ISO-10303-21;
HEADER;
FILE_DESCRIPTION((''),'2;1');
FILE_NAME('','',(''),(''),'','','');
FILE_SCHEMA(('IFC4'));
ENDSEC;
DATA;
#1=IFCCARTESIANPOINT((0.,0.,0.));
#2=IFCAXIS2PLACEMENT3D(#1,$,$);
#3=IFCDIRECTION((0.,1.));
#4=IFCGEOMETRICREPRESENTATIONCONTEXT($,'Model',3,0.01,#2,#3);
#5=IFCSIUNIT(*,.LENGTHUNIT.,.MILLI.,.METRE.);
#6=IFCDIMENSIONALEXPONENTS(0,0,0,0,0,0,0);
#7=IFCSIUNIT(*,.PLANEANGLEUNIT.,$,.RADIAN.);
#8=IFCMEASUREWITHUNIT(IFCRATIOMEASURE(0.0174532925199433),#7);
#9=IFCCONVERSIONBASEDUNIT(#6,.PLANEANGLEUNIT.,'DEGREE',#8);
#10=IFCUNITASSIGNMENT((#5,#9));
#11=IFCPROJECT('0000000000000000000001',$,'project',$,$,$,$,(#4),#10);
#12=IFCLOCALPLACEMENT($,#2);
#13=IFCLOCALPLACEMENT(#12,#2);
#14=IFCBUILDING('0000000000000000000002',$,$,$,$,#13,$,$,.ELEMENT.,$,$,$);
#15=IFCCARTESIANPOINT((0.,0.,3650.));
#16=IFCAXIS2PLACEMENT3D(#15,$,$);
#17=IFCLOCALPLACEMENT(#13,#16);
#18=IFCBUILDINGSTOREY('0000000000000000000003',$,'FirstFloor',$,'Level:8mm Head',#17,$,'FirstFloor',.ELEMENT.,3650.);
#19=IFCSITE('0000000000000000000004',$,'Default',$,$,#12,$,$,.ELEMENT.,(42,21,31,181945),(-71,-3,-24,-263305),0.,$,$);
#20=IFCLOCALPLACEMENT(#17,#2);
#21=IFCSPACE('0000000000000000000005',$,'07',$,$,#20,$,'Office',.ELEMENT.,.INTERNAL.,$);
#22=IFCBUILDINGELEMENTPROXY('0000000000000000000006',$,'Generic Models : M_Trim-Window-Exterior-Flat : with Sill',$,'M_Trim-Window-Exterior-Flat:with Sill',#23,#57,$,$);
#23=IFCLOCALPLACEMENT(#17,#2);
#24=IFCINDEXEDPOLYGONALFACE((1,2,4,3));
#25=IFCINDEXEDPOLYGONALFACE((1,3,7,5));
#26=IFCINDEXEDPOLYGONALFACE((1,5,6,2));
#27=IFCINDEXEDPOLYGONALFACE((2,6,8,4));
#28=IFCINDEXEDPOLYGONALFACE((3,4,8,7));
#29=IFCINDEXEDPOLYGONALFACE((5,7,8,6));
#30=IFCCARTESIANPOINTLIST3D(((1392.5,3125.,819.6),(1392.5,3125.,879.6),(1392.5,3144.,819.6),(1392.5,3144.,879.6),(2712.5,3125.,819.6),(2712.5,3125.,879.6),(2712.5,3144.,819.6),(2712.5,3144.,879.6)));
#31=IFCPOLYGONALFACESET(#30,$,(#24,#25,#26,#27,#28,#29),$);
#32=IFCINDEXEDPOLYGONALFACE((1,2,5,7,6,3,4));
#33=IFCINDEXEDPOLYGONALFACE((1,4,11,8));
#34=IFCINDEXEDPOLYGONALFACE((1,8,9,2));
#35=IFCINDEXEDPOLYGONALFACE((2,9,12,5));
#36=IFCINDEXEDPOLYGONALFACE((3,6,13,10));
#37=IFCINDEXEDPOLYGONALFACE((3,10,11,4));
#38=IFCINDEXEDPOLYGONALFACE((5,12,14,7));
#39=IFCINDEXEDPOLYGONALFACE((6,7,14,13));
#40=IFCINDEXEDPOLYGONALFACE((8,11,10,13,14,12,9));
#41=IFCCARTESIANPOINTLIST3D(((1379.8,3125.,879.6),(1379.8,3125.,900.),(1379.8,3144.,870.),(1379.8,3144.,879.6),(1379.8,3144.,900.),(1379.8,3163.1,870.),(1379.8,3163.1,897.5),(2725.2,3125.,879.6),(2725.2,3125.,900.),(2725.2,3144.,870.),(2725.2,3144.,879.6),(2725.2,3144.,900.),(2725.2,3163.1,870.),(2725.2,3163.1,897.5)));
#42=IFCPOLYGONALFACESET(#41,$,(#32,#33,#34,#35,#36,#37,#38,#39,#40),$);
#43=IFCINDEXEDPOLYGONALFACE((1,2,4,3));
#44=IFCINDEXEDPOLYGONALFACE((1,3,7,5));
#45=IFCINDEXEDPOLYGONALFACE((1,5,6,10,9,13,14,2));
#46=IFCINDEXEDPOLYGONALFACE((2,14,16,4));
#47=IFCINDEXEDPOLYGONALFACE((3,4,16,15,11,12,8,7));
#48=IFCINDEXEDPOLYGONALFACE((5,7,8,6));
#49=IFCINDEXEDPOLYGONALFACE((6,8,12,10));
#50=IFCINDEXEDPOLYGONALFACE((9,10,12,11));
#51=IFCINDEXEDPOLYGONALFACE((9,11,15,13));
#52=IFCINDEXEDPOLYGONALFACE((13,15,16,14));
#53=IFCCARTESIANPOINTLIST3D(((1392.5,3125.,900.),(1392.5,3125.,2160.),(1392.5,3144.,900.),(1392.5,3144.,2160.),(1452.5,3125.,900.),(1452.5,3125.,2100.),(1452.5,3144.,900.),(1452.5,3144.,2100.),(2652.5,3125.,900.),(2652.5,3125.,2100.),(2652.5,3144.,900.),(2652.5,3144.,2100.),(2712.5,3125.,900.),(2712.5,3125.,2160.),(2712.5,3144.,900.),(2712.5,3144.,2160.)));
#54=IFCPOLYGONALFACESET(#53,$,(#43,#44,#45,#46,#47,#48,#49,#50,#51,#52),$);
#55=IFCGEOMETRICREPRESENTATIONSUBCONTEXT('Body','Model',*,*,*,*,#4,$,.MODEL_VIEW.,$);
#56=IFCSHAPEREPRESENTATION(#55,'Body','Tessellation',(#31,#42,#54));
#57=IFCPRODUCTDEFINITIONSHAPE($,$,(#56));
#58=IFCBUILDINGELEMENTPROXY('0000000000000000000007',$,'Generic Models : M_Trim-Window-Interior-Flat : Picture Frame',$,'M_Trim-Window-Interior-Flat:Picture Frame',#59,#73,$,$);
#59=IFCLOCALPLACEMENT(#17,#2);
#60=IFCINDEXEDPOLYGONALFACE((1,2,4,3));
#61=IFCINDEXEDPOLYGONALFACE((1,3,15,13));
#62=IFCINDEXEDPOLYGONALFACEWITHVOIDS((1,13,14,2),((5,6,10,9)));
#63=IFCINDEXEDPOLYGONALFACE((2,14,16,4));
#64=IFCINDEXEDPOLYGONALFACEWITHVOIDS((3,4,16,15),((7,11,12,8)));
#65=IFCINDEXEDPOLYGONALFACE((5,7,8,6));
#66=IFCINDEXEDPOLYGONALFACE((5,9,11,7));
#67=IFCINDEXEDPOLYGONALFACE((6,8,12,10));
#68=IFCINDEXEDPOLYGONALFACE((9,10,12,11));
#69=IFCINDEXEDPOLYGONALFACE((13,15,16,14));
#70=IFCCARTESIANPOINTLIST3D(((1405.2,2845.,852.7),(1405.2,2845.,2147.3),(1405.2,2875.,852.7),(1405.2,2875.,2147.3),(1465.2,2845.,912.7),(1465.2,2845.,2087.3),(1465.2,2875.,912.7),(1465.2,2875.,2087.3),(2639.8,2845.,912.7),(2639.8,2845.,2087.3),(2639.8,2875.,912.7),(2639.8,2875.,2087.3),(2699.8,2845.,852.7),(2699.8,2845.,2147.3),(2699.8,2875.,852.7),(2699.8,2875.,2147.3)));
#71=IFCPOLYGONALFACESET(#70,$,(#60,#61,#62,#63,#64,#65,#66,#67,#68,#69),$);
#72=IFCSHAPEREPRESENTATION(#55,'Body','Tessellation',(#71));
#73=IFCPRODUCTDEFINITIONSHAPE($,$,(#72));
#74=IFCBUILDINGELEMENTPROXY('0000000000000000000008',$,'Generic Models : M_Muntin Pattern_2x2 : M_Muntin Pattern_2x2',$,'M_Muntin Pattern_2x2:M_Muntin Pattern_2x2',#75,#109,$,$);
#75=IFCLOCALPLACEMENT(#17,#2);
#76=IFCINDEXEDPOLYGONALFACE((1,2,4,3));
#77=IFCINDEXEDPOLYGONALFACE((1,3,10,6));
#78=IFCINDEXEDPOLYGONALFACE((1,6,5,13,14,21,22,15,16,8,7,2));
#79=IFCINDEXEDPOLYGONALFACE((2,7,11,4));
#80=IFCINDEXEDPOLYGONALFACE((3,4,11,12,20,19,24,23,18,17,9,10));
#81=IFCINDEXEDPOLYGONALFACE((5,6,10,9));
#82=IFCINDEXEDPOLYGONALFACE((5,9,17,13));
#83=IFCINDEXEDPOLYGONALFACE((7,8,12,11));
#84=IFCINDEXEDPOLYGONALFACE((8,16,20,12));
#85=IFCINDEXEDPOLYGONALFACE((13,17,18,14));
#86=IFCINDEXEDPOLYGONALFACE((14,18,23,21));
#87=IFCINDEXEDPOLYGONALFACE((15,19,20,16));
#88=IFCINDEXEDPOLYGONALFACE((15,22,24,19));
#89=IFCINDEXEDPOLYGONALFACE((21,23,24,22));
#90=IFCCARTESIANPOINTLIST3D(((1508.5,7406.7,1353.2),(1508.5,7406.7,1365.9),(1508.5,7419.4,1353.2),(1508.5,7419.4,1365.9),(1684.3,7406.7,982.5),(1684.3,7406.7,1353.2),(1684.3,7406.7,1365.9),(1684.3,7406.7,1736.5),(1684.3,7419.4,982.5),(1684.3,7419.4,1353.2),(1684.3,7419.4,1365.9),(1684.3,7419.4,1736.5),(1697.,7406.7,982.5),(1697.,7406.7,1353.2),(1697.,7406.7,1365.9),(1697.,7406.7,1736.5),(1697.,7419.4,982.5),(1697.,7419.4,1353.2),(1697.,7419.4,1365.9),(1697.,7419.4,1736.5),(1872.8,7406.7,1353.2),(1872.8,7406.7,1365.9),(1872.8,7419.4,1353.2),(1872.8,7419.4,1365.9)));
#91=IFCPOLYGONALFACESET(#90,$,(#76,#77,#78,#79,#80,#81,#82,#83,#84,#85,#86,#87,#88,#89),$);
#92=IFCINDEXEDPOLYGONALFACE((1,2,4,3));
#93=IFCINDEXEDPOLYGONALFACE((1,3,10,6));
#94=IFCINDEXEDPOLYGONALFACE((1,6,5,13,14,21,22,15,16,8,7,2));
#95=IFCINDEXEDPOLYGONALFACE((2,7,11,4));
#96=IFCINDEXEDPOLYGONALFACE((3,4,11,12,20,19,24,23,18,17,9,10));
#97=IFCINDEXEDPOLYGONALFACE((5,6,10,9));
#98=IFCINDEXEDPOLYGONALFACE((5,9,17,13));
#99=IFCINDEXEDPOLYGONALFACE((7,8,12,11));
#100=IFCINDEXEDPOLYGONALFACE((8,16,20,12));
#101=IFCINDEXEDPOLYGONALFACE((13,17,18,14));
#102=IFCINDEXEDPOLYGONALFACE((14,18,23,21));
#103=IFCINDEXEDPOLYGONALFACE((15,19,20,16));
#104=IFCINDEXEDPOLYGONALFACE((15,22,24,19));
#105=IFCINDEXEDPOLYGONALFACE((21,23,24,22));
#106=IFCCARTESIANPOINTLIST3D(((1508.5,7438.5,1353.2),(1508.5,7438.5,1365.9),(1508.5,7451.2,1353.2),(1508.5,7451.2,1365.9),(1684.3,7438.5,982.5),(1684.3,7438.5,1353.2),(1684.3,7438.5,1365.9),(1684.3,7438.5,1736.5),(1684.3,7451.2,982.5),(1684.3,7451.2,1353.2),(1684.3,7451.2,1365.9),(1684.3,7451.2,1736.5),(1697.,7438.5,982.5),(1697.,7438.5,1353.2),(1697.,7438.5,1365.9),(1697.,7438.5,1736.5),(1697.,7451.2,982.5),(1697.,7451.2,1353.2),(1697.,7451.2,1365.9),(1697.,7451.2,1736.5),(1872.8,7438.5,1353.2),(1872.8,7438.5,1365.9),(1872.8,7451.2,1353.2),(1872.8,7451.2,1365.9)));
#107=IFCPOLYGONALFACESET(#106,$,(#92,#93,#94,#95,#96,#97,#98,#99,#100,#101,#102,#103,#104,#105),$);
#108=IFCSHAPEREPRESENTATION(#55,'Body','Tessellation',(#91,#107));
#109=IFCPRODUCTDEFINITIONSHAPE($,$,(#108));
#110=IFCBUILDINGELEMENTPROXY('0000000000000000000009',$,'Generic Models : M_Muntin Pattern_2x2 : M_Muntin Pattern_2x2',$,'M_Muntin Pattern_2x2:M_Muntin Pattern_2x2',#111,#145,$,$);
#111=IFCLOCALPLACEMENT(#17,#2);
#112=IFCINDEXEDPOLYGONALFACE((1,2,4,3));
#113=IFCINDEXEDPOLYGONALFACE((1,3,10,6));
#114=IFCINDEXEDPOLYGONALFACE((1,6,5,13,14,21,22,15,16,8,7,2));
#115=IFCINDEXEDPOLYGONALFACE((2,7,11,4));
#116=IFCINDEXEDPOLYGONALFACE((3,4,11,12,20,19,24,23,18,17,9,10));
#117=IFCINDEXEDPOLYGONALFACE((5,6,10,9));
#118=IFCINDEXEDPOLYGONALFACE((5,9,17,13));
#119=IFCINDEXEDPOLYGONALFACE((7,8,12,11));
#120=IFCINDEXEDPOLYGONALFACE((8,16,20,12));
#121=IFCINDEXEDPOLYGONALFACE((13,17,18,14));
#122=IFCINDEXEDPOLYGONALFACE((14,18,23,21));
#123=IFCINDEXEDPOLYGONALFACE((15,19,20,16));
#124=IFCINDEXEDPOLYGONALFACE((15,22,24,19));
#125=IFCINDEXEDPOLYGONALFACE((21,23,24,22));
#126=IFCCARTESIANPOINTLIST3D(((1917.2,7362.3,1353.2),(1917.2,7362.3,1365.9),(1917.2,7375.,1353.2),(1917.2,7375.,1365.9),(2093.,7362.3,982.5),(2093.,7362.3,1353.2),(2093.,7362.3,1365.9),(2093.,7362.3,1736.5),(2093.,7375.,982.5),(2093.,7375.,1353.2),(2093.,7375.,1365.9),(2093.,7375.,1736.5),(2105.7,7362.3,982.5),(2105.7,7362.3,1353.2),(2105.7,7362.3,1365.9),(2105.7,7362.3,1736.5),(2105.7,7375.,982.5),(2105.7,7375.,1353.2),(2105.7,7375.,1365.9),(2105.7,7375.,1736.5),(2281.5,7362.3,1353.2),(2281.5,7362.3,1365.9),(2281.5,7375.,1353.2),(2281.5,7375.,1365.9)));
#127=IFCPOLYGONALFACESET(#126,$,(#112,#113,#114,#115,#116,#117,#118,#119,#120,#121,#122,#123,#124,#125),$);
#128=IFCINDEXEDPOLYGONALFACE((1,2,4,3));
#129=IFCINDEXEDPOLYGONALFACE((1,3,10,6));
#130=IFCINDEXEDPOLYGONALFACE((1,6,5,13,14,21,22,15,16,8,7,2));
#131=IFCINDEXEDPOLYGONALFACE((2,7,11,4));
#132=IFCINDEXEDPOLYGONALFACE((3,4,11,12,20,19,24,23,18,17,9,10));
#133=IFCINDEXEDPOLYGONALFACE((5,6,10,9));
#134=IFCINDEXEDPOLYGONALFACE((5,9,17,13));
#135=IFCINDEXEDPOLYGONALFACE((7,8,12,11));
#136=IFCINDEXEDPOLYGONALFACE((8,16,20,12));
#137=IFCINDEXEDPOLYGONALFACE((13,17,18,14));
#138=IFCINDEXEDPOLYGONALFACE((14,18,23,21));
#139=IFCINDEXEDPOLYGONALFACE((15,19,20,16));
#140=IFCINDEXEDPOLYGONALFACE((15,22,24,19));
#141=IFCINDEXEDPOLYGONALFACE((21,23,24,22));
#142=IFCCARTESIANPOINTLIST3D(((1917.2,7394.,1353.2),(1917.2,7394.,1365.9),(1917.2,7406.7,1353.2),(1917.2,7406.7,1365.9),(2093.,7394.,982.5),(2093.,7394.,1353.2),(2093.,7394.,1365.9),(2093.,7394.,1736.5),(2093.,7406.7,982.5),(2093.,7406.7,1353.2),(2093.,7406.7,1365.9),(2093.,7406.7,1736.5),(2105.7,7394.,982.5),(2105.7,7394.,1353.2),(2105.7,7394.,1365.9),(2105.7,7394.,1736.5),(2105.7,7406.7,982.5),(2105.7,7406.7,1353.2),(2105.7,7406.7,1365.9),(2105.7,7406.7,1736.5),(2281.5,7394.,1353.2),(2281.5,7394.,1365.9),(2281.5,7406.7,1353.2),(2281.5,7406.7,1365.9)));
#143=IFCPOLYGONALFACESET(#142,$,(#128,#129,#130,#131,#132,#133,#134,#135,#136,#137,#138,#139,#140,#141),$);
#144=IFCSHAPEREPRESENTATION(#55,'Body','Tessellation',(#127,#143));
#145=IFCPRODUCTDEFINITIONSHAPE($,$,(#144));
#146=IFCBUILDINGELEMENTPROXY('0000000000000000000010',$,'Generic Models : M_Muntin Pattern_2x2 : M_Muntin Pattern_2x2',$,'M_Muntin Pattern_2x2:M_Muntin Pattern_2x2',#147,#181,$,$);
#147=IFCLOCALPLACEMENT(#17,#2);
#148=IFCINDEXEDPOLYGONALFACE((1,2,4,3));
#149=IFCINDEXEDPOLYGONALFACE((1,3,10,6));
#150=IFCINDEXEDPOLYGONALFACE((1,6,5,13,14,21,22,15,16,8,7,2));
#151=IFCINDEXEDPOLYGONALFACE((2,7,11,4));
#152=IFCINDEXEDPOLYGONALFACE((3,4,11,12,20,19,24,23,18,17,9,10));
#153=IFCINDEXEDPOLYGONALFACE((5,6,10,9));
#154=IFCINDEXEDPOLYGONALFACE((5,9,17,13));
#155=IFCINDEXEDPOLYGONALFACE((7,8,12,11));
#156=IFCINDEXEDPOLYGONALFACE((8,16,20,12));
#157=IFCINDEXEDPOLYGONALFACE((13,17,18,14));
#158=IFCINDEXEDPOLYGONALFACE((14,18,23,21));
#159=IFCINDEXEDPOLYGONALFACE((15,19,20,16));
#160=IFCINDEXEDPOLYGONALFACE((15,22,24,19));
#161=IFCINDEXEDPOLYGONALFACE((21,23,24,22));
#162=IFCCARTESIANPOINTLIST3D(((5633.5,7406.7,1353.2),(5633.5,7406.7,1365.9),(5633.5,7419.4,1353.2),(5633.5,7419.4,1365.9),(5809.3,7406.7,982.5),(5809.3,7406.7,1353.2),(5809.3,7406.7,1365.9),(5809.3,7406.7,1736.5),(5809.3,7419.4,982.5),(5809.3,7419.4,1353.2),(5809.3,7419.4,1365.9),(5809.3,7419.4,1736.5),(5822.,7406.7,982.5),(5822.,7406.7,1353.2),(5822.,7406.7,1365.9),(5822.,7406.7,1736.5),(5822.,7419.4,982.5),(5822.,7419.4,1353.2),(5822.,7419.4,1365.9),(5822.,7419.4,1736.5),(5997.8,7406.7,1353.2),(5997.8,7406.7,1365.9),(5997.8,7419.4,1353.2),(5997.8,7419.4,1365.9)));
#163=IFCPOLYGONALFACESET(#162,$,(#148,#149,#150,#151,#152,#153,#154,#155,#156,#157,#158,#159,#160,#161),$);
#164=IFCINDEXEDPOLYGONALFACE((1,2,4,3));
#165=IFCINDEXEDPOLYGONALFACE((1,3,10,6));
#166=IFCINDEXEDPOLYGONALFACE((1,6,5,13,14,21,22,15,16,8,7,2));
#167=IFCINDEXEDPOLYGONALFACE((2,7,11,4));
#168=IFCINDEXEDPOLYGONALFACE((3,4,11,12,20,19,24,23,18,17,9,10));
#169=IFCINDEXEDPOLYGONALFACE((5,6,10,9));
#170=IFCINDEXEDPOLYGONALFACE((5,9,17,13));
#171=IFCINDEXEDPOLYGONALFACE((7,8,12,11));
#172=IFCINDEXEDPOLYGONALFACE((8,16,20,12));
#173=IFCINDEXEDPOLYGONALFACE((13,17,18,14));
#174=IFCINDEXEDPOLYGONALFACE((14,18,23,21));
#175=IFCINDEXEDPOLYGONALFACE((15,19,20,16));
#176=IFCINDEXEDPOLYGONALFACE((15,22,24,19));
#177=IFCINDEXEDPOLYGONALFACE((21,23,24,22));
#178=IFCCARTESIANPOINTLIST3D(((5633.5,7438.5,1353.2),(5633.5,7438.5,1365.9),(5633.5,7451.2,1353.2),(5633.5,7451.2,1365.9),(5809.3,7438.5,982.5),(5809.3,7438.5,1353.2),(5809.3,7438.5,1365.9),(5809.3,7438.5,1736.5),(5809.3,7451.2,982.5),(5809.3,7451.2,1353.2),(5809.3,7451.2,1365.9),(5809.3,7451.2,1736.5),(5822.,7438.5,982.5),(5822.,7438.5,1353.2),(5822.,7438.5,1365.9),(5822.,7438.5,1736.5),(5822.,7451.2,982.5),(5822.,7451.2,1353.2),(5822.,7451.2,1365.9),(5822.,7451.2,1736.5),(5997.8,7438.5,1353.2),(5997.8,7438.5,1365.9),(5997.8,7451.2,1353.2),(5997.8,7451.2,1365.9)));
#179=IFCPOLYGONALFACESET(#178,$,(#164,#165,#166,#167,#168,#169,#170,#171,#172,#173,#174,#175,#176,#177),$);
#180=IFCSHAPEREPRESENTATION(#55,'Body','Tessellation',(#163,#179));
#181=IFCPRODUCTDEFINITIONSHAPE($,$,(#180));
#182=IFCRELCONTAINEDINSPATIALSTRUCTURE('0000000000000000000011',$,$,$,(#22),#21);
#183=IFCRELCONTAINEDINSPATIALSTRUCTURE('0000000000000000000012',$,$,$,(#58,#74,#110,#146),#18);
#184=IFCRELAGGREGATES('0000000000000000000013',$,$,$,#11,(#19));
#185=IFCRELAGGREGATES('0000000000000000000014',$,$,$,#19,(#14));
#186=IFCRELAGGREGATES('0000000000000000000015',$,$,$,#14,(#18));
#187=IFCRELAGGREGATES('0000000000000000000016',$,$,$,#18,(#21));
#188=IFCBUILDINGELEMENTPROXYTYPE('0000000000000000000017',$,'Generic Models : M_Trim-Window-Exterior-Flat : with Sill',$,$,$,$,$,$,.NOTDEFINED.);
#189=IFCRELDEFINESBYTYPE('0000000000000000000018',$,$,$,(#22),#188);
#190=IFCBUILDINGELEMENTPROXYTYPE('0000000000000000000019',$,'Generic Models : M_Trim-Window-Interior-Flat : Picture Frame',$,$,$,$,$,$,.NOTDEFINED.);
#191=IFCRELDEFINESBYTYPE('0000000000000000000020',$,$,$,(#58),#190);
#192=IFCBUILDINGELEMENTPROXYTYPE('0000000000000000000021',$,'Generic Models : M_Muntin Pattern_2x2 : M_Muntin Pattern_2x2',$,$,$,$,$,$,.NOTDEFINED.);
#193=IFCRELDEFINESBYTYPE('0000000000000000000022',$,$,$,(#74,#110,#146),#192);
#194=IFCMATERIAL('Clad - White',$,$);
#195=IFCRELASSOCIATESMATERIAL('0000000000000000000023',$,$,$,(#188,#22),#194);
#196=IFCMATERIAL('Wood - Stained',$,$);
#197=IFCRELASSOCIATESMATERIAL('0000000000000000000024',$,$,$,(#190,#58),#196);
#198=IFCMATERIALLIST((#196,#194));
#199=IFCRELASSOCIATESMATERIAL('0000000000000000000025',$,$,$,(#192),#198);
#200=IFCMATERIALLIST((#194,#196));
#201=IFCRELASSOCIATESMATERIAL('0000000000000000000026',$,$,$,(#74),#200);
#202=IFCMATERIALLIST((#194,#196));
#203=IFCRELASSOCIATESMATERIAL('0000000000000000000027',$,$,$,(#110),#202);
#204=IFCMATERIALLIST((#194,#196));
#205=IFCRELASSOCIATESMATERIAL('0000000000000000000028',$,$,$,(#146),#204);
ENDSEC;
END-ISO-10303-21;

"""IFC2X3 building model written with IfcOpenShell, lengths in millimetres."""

from ifc_helpers import new_model, entity, si_unit, converted_unit, direction, frame, frame_2d, origin, place, context, subcontext, project, spatial, polyline, rectangle, outline, extrude, source, transform, mapped, material, material_list, type_object, type_shapes, element, save


model = new_model("IFC2X3")

# Units and contexts
model_context = context("Model", 3, precision=0.01, world=origin(), true_north=direction((0.0, 1.0)))
body_context = subcontext(model_context, "Body", "Model", "MODEL_VIEW")
ifc_project = project(units=[si_unit("LENGTHUNIT", "METRE", prefix="MILLI"), converted_unit("PLANEANGLEUNIT", "DEGREE", entity("IfcRatioMeasure", 0.0174532925199433), si_unit("PLANEANGLEUNIT", "RADIAN"), dimensions=[0, 0, 0, 0, 0, 0, 0])], contexts=[model_context])

# Site, building, storey
site_placement = place(None, origin())
site = spatial("IfcSite", under=ifc_project, at=site_placement, Name="Default", CompositionType="ELEMENT", RefLatitude=(42, 21, 31, 181945), RefLongitude=(-71, -3, -24, -263305), RefElevation=0.0)
building_placement = place(site_placement, origin())
building = spatial("IfcBuilding", under=site, at=building_placement, CompositionType="ELEMENT")
storey_placement = place(building_placement, frame((0.0, 0.0, 3650.0)))
storey = spatial("IfcBuildingStorey", under=building, at=storey_placement, Name="FirstFloor", ObjectType="Level:8mm Head", LongName="FirstFloor", CompositionType="ELEMENT", Elevation=3650.0)

# Shared definitions
ifc_material_1 = material(Name="Clad - White")
ifc_material_2 = material(Name="Wood - Stained")

# Shared definitions
space_placement = place(storey_placement, origin())
space = spatial("IfcSpace", under=storey, at=space_placement, Name="07", LongName="Office", CompositionType="ELEMENT", InteriorOrExteriorSpace="INTERNAL")

# Building element proxies
building_element_proxy_type_1 = type_object("IfcBuildingElementProxyType", Name="Generic Models : M_Trim-Window-Exterior-Flat : with Sill", PredefinedType="NOTDEFINED", material=ifc_material_1)
shared_shape_1 = source(origin(), body_context, "Body", "SweptSolid", [
    extrude(rectangle(XDim=1320.0, YDim=60.0, at=frame_2d((0.0, 0.0), x_axis=(1.0, 0.0))), frame((0.0, -1250.4, 0.0), z_axis=(0.0, 0.0, 1.0), x_axis=(-1.0, 0.0, 0.0)), (0.0, 0.0, 1.0), 19.1),
    extrude(outline(polyline([(-19.0, -15.2), (0.0, -15.2), (0.0, -5.7), (19.0, -5.7), (19.0, 14.8), (0.0, 14.8), (-19.0, 12.3), (-19.0, -15.2)])), frame((-672.7, -1214.8, 19.0), z_axis=(1.0, 0.0, 0.0), x_axis=(0.0, 0.0, -1.0)), (0.0, 0.0, 1.0), 1345.4),
    extrude(outline(polyline([(-645.0, -660.0), (615.0, -660.0), (615.0, -600.0), (-585.0, -600.0), (-585.0, 600.0), (615.0, 600.0), (615.0, 660.0), (-645.0, 660.0), (-645.0, -660.0)])), frame((0.0, -585.0, 0.0), z_axis=(0.0, 0.0, 1.0), x_axis=(0.0, -1.0, 0.0)), (0.0, 0.0, 1.0), 19.1),
])
type_shapes(building_element_proxy_type_1, [shared_shape_1])
proxy_1_placement = place(space_placement, frame((2052.5, 3125.0, 2100.0), z_axis=(0.0, 1.0, 0.0), x_axis=(-1.0, 0.0, 0.0)))
element("IfcBuildingElementProxy", 1, at=proxy_1_placement, inside=space, type_object=building_element_proxy_type_1, material=ifc_material_1, Name="Generic Models : M_Trim-Window-Exterior-Flat : with Sill", ObjectType="M_Trim-Window-Exterior-Flat:with Sill", context=body_context, shape_type="MappedRepresentation", body=[
    mapped(shared_shape_1, transform((0.0, 0.0, 0.0), scale=1.0)),
])
building_element_proxy_type_2 = type_object("IfcBuildingElementProxyType", Name="Generic Models : M_Trim-Window-Interior-Flat : Picture Frame", PredefinedType="NOTDEFINED", material=ifc_material_2)
shared_shape_2 = source(origin(), body_context, "Body", "SweptSolid", [
    extrude(outline(polyline([(-647.3, -647.3), (647.3, -647.3), (647.3, 647.3), (-647.3, 647.3), (-647.3, -647.3)]), holes=[polyline([(-587.3, -587.3), (-587.3, 587.3), (587.3, 587.3), (587.3, -587.3), (-587.3, -587.3)])]), frame((0.0, -600.0, 0.0), z_axis=(0.0, 0.0, 1.0), x_axis=(-1.0, 0.0, 0.0)), (0.0, 0.0, 1.0), 30.0),
])
type_shapes(building_element_proxy_type_2, [shared_shape_2])
proxy_2_placement = place(storey_placement, frame((2052.5, 2875.0, 2100.0), z_axis=(0.0, -1.0, 0.0), x_axis=(1.0, 0.0, 0.0)))
element("IfcBuildingElementProxy", 2, at=proxy_2_placement, inside=storey, type_object=building_element_proxy_type_2, material=ifc_material_2, Name="Generic Models : M_Trim-Window-Interior-Flat : Picture Frame", ObjectType="M_Trim-Window-Interior-Flat:Picture Frame", context=body_context, shape_type="MappedRepresentation", body=[
    mapped(shared_shape_2, transform((0.0, 0.0, 0.0), scale=1.0)),
])
ifc_material_list_1 = material_list([ifc_material_1, ifc_material_2])
ifc_material_list_2 = material_list([ifc_material_2, ifc_material_1])
building_element_proxy_type_3 = type_object("IfcBuildingElementProxyType", Name="Generic Models : M_Muntin Pattern_2x2 : M_Muntin Pattern_2x2", PredefinedType="NOTDEFINED", material=ifc_material_list_2)
shared_shape_3 = source(origin(), body_context, "Body", "SweptSolid", [
    extrude(outline(polyline([(6.4, -6.4), (377.0, -6.4), (377.0, 6.3), (6.4, 6.3), (6.4, 182.1), (-6.3, 182.1), (-6.3, 6.3), (-377.0, 6.3), (-377.0, -6.4), (-6.3, -6.4), (-6.3, -182.1), (6.4, -182.1), (6.4, -6.4)])), frame((0.0, 9.5, 377.0), z_axis=(0.0, 1.0, 0.0), x_axis=(0.0, 0.0, 1.0)), (0.0, 0.0, 1.0), 12.7),
    extrude(outline(polyline([(6.4, -6.4), (377.0, -6.4), (377.0, 6.3), (6.4, 6.3), (6.4, 182.1), (-6.3, 182.1), (-6.3, 6.3), (-377.0, 6.3), (-377.0, -6.4), (-6.3, -6.4), (-6.3, -182.1), (6.4, -182.1), (6.4, -6.4)])), frame((0.0, -22.2, 377.0), z_axis=(0.0, 1.0, 0.0), x_axis=(0.0, 0.0, 1.0)), (0.0, 0.0, 1.0), 12.7),
])
type_shapes(building_element_proxy_type_3, [shared_shape_3])
proxy_3_placement = place(storey_placement, frame((1690.6, 7429.0, 982.5), z_axis=(0.0, 0.0, 1.0), x_axis=(-1.0, 0.0, 0.0)))
element("IfcBuildingElementProxy", 3, at=proxy_3_placement, inside=storey, type_object=building_element_proxy_type_3, material=ifc_material_list_1, Name="Generic Models : M_Muntin Pattern_2x2 : M_Muntin Pattern_2x2", ObjectType="M_Muntin Pattern_2x2:M_Muntin Pattern_2x2", context=body_context, shape_type="MappedRepresentation", body=[
    mapped(shared_shape_3, transform((0.0, 0.0, 0.0), scale=1.0)),
])
ifc_material_list_3 = material_list([ifc_material_1, ifc_material_2])
proxy_4_placement = place(storey_placement, frame((2099.4, 7384.5, 982.5), z_axis=(0.0, 0.0, 1.0), x_axis=(-1.0, 0.0, 0.0)))
element("IfcBuildingElementProxy", 4, at=proxy_4_placement, inside=storey, type_object=building_element_proxy_type_3, material=ifc_material_list_3, Name="Generic Models : M_Muntin Pattern_2x2 : M_Muntin Pattern_2x2", ObjectType="M_Muntin Pattern_2x2:M_Muntin Pattern_2x2", context=body_context, shape_type="MappedRepresentation", body=[
    mapped(shared_shape_3, transform((0.0, 0.0, 0.0), scale=1.0)),
])
ifc_material_list_4 = material_list([ifc_material_1, ifc_material_2])
proxy_5_placement = place(storey_placement, frame((5815.6, 7429.0, 982.5), z_axis=(0.0, 0.0, 1.0), x_axis=(-1.0, 0.0, 0.0)))
element("IfcBuildingElementProxy", 5, at=proxy_5_placement, inside=storey, type_object=building_element_proxy_type_3, material=ifc_material_list_4, Name="Generic Models : M_Muntin Pattern_2x2 : M_Muntin Pattern_2x2", ObjectType="M_Muntin Pattern_2x2:M_Muntin Pattern_2x2", context=body_context, shape_type="MappedRepresentation", body=[
    mapped(shared_shape_3, transform((0.0, 0.0, 0.0), scale=1.0)),
])

save(model, "model.ifc")
